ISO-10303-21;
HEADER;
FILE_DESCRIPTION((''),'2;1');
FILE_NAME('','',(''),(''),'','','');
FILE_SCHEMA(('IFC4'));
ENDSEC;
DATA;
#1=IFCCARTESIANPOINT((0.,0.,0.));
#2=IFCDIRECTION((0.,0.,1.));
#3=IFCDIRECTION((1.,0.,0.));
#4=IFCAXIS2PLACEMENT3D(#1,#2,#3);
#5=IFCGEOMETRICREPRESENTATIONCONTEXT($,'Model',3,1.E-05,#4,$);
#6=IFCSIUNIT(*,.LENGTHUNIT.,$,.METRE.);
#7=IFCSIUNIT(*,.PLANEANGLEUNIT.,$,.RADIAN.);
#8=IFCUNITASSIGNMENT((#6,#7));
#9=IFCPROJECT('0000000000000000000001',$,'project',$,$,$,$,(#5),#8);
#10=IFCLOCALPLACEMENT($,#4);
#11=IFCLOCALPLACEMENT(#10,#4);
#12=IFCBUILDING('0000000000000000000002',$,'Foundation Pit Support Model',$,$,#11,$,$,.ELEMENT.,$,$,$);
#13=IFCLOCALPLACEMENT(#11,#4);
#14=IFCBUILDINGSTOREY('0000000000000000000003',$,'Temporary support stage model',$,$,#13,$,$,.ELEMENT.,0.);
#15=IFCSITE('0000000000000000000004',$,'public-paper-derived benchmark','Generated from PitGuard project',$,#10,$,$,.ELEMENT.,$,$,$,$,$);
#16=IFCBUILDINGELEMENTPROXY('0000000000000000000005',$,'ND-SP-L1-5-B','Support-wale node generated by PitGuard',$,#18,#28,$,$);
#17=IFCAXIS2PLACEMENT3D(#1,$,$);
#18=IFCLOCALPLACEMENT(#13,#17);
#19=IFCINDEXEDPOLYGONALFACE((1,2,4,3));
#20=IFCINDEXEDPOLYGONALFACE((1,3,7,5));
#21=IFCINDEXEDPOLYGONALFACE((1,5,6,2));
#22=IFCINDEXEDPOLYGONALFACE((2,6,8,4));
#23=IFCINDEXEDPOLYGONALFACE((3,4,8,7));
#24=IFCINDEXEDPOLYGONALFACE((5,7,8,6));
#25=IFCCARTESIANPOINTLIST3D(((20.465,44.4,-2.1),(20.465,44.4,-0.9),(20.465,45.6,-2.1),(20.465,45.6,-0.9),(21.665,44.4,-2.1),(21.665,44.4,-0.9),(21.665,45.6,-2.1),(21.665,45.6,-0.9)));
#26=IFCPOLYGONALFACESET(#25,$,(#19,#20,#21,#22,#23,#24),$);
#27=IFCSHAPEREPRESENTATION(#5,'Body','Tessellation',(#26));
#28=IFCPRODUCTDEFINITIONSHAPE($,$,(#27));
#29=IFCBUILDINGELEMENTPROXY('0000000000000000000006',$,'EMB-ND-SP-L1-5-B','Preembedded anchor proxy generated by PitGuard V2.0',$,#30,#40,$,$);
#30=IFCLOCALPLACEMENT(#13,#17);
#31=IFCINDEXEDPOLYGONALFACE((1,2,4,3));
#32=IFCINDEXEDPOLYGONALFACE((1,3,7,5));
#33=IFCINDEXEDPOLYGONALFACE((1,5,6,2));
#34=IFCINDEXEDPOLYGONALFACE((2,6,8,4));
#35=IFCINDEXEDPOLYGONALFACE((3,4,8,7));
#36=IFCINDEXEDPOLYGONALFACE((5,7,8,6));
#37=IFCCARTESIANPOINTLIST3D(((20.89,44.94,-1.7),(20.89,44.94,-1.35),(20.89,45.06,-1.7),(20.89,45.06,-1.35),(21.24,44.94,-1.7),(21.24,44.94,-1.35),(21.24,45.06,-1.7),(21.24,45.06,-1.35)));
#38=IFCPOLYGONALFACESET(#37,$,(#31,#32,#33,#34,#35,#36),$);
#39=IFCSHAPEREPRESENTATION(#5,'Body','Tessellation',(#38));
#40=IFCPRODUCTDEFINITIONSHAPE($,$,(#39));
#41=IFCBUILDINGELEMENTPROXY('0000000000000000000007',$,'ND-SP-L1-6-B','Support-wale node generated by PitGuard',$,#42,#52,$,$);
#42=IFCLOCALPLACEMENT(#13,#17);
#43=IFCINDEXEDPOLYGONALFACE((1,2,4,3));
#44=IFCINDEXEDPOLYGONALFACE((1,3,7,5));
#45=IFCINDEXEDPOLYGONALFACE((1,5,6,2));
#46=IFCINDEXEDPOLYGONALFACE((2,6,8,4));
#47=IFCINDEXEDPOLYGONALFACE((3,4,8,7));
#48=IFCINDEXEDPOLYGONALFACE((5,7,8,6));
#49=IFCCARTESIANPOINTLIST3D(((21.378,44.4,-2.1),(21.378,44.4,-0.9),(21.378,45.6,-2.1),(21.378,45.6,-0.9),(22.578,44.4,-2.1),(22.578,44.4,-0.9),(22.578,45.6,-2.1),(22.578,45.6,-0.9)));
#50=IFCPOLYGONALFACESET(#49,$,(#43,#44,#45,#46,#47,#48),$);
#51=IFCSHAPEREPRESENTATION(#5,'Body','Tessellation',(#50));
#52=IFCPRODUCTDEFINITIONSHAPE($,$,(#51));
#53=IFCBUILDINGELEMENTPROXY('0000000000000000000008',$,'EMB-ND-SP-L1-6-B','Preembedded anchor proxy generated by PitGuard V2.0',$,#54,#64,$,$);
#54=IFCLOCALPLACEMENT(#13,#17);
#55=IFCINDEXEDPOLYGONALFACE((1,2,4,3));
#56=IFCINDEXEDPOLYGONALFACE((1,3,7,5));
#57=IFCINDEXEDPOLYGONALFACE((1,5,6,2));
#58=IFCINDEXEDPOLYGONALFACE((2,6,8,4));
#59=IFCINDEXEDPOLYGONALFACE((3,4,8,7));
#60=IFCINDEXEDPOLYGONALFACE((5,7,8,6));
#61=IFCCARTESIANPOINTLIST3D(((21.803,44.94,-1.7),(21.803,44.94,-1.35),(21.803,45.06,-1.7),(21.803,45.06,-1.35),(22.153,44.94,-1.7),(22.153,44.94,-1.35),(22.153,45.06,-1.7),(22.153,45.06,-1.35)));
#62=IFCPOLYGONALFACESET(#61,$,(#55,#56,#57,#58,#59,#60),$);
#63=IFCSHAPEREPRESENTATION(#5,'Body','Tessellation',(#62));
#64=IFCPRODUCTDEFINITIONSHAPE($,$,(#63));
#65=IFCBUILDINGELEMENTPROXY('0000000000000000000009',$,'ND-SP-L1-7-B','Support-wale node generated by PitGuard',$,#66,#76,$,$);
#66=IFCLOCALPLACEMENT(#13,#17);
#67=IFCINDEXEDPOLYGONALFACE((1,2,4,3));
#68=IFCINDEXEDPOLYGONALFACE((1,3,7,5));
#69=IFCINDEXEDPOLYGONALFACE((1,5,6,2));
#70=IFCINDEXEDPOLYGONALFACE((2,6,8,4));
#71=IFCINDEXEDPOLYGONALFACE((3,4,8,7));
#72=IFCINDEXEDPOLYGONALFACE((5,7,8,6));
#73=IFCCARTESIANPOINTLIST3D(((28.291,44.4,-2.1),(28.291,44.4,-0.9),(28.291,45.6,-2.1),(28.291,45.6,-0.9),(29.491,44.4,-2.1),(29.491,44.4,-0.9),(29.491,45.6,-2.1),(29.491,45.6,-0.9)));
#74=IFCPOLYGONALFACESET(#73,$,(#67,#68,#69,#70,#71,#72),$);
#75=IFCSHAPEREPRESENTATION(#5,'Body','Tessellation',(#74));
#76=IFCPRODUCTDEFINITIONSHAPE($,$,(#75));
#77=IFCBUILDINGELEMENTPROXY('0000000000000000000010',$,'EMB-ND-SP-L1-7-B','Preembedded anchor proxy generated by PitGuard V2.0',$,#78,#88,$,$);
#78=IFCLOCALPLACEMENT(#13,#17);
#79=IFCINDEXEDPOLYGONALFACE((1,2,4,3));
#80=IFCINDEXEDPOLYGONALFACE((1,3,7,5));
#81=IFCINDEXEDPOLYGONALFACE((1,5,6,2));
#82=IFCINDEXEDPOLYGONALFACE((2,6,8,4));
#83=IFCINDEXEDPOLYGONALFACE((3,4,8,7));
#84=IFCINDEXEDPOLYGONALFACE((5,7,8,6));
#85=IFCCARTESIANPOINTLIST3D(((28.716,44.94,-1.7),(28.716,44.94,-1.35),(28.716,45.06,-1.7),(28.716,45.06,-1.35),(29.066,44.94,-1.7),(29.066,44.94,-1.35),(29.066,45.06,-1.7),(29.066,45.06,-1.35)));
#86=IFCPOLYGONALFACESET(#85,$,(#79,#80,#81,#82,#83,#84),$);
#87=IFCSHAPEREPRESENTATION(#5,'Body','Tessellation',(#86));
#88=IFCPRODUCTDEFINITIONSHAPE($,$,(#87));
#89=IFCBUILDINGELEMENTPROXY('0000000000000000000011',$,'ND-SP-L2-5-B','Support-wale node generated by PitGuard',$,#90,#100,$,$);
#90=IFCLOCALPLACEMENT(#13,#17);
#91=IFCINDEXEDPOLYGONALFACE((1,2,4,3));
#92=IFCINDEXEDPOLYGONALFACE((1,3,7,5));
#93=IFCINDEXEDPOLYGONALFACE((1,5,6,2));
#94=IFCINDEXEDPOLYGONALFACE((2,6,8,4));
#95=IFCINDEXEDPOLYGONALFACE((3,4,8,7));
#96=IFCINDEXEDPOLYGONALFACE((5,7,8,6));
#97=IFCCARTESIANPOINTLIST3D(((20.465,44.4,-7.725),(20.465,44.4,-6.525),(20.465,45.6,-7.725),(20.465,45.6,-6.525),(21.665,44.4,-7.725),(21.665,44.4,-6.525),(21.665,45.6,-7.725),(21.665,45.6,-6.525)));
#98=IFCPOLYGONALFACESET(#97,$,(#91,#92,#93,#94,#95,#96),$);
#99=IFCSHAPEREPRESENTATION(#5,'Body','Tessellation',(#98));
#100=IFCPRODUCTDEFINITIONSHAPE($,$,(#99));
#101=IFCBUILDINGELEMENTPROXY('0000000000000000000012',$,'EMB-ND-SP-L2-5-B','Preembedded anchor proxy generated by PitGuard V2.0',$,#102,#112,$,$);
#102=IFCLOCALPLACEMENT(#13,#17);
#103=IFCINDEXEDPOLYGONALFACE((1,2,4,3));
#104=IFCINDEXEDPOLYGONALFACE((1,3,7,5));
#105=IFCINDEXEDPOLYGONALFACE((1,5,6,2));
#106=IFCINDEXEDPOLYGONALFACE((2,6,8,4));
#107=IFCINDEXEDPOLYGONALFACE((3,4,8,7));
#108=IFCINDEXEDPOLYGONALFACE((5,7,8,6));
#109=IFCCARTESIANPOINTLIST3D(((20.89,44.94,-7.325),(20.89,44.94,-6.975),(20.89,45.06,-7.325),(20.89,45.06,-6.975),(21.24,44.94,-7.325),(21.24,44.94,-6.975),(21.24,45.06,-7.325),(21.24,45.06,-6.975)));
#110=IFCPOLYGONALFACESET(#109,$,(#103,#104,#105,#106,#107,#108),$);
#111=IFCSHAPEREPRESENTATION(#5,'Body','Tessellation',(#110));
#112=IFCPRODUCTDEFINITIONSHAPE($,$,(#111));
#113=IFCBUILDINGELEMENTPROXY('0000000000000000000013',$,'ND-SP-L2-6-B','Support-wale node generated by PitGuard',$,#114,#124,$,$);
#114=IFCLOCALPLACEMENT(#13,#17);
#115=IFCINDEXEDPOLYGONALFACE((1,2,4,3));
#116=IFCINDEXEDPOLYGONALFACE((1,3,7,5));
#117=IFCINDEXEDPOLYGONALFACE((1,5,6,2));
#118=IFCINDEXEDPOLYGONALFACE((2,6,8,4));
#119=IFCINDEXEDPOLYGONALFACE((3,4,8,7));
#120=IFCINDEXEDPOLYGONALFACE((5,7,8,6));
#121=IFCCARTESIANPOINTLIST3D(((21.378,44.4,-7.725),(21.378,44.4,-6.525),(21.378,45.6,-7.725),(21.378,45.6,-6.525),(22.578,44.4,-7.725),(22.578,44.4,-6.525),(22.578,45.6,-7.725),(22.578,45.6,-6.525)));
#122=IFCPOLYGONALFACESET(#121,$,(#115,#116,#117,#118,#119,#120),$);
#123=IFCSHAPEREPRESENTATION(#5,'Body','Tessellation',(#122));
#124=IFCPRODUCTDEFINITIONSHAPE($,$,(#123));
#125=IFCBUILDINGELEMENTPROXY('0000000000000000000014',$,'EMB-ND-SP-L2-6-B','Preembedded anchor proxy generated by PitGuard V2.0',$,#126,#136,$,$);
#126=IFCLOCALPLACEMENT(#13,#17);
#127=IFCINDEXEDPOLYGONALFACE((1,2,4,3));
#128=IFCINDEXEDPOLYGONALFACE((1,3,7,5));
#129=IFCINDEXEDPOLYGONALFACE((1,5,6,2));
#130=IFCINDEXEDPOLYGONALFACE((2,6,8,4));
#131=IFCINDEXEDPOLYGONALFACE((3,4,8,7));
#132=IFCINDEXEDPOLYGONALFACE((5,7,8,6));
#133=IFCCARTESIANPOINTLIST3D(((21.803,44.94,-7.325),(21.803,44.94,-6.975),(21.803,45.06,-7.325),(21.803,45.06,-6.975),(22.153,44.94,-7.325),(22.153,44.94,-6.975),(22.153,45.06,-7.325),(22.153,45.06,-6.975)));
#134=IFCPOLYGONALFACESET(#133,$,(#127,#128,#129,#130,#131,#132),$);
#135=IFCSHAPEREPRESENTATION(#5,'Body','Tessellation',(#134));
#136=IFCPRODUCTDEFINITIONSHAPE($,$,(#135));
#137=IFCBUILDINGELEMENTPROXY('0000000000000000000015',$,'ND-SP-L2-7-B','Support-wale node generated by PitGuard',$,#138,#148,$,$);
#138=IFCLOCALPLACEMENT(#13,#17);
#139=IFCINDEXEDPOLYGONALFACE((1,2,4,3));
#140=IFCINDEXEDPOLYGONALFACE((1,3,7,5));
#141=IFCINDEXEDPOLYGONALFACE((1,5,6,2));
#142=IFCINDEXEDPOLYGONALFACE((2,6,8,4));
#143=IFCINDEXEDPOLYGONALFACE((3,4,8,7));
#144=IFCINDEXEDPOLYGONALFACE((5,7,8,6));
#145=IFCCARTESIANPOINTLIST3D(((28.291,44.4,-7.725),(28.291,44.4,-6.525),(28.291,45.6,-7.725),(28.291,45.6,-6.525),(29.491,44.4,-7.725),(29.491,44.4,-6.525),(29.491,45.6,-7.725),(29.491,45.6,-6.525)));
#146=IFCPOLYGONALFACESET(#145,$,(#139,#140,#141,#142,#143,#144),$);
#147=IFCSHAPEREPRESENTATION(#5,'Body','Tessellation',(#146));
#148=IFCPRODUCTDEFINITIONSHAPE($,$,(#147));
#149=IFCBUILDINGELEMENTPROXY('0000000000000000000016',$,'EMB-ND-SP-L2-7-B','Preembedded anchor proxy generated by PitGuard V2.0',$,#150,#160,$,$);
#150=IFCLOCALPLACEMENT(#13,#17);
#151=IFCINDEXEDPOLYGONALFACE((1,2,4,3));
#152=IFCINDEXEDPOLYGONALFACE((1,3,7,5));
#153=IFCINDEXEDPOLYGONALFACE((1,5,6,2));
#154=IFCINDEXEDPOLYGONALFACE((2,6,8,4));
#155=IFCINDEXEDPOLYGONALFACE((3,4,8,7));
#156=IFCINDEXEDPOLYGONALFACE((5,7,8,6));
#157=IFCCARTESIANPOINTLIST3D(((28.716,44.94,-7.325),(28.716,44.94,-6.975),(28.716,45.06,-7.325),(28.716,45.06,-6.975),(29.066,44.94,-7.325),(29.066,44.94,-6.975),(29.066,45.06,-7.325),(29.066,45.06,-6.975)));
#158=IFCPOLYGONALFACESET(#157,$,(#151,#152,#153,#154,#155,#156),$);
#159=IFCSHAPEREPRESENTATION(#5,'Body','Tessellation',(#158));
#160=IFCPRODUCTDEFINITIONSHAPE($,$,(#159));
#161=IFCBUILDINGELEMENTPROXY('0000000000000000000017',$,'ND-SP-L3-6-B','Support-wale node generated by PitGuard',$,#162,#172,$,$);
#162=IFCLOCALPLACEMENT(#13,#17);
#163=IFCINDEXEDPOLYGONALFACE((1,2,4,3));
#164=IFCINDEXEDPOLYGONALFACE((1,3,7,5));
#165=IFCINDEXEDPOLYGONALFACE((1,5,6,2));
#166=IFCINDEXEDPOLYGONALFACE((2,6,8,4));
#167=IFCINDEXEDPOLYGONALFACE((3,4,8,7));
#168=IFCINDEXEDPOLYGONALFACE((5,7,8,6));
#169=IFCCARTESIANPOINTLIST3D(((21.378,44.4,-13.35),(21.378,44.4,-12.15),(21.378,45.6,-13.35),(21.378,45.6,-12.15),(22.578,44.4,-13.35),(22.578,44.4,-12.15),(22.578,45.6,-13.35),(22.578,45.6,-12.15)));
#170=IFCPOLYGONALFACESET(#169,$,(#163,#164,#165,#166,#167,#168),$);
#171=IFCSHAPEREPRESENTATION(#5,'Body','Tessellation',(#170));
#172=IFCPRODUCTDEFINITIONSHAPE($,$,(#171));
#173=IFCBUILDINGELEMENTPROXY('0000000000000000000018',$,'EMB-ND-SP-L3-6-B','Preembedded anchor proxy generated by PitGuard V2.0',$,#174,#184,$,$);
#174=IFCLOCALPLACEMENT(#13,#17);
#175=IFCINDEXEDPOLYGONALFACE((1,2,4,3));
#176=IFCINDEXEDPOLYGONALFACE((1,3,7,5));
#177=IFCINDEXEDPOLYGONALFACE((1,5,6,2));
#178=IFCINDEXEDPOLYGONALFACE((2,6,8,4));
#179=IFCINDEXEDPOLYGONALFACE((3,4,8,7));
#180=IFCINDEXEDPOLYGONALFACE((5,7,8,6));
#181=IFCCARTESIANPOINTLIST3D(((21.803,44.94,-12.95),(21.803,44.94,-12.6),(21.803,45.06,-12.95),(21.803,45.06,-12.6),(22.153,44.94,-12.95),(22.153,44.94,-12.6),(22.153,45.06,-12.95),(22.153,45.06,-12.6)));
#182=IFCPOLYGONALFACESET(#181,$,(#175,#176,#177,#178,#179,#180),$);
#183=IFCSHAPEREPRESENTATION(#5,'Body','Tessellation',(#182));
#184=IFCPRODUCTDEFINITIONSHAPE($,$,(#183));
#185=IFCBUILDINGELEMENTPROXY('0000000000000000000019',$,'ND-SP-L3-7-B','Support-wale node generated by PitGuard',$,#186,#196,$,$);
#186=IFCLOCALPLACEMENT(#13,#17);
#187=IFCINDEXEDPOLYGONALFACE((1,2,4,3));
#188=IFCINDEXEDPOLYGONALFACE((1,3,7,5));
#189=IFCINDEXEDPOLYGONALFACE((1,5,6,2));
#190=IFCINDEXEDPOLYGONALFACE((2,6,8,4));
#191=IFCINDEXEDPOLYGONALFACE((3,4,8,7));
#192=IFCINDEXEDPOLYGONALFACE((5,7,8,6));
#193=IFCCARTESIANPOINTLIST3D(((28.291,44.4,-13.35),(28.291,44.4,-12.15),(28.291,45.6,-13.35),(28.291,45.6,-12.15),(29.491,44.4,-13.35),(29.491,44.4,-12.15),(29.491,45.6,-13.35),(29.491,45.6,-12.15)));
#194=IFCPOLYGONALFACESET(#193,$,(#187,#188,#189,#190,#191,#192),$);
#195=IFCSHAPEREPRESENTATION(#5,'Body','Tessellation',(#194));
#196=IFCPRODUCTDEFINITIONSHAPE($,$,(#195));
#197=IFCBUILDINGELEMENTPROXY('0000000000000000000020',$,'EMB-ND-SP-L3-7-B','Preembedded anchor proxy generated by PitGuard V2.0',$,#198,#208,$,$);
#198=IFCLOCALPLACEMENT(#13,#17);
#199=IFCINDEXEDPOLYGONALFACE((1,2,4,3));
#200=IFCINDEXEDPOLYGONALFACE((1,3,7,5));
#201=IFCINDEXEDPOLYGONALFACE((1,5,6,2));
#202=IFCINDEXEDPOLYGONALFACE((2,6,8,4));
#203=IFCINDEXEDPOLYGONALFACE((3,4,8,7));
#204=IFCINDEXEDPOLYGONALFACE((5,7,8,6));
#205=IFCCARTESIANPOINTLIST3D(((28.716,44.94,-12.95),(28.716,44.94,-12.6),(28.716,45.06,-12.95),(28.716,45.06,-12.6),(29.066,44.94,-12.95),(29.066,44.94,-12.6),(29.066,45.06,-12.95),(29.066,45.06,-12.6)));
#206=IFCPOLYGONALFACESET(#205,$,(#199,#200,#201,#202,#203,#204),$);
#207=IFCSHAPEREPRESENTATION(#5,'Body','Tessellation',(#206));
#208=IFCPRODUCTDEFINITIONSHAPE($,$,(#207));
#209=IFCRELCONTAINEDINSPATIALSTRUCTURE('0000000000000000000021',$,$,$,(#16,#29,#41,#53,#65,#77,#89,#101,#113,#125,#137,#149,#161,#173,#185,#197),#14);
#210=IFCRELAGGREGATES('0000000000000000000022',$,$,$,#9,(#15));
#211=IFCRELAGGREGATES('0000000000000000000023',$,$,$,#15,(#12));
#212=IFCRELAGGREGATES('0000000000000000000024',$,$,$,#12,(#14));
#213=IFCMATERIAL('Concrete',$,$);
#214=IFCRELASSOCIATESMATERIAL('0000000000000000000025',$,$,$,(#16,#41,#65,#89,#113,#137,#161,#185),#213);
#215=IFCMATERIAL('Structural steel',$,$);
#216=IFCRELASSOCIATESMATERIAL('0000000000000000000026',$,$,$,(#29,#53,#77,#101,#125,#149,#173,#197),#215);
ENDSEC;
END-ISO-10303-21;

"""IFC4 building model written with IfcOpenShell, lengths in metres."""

from ifc_helpers import new_model, si_unit, frame, origin_with_axes, origin_2d, place, context, project, spatial, rectangle, extrude, material, element, save


model = new_model("IFC4")

# Units and contexts
model_context = context("Model", 3, precision=1e-05, world=origin_with_axes())
ifc_project = project(units=[si_unit("LENGTHUNIT", "METRE"), si_unit("PLANEANGLEUNIT", "RADIAN")], contexts=[model_context])

# Site, building, storey
site_placement = place(None, origin_with_axes())
site = spatial("IfcSite", under=ifc_project, at=site_placement, Name="public-paper-derived benchmark", Description="Generated from PitGuard project", CompositionType="ELEMENT")
building_placement = place(site_placement, origin_with_axes())
building = spatial("IfcBuilding", under=site, at=building_placement, Name="Foundation Pit Support Model", CompositionType="ELEMENT")
storey_placement = place(building_placement, origin_with_axes())
storey = spatial("IfcBuildingStorey", under=building, at=storey_placement, Name="Temporary support stage model", CompositionType="ELEMENT", Elevation=0.0)

# Shared definitions
ifc_material_1 = material(Name="Concrete")

# Shared definitions
ifc_material_2 = material(Name="Structural steel")

# Building element proxies
proxy_1_placement = place(storey_placement, frame((21.065, 45.0, -2.1), z_axis=(0.0, 0.0, 1.0), x_axis=(1.0, 0.0, 0.0)))
element("IfcBuildingElementProxy", 1, at=proxy_1_placement, inside=storey, material=ifc_material_1, Name="ND-SP-L1-5-B", Description="Support-wale node generated by PitGuard", context=model_context, shape_type="SweptSolid", body=[
    extrude(rectangle(XDim=1.2, YDim=1.2, at=origin_2d()), origin_with_axes(), (0.0, 0.0, 1.0), 1.2),
])
proxy_2_placement = place(storey_placement, frame((21.065, 45.0, -1.7), z_axis=(0.0, 0.0, 1.0), x_axis=(1.0, 0.0, 0.0)))
element("IfcBuildingElementProxy", 2, at=proxy_2_placement, inside=storey, material=ifc_material_2, Name="EMB-ND-SP-L1-5-B", Description="Preembedded anchor proxy generated by PitGuard V2.0", context=model_context, shape_type="SweptSolid", body=[
    extrude(rectangle(XDim=0.35, YDim=0.12, at=origin_2d()), origin_with_axes(), (0.0, 0.0, 1.0), 0.35),
])
proxy_3_placement = place(storey_placement, frame((21.978, 45.0, -2.1), z_axis=(0.0, 0.0, 1.0), x_axis=(1.0, 0.0, 0.0)))
element("IfcBuildingElementProxy", 3, at=proxy_3_placement, inside=storey, material=ifc_material_1, Name="ND-SP-L1-6-B", Description="Support-wale node generated by PitGuard", context=model_context, shape_type="SweptSolid", body=[
    extrude(rectangle(XDim=1.2, YDim=1.2, at=origin_2d()), origin_with_axes(), (0.0, 0.0, 1.0), 1.2),
])
proxy_4_placement = place(storey_placement, frame((21.978, 45.0, -1.7), z_axis=(0.0, 0.0, 1.0), x_axis=(1.0, 0.0, 0.0)))
element("IfcBuildingElementProxy", 4, at=proxy_4_placement, inside=storey, material=ifc_material_2, Name="EMB-ND-SP-L1-6-B", Description="Preembedded anchor proxy generated by PitGuard V2.0", context=model_context, shape_type="SweptSolid", body=[
    extrude(rectangle(XDim=0.35, YDim=0.12, at=origin_2d()), origin_with_axes(), (0.0, 0.0, 1.0), 0.35),
])
proxy_5_placement = place(storey_placement, frame((28.891, 45.0, -2.1), z_axis=(0.0, 0.0, 1.0), x_axis=(1.0, 0.0, 0.0)))
element("IfcBuildingElementProxy", 5, at=proxy_5_placement, inside=storey, material=ifc_material_1, Name="ND-SP-L1-7-B", Description="Support-wale node generated by PitGuard", context=model_context, shape_type="SweptSolid", body=[
    extrude(rectangle(XDim=1.2, YDim=1.2, at=origin_2d()), origin_with_axes(), (0.0, 0.0, 1.0), 1.2),
])
proxy_6_placement = place(storey_placement, frame((28.891, 45.0, -1.7), z_axis=(0.0, 0.0, 1.0), x_axis=(1.0, 0.0, 0.0)))
element("IfcBuildingElementProxy", 6, at=proxy_6_placement, inside=storey, material=ifc_material_2, Name="EMB-ND-SP-L1-7-B", Description="Preembedded anchor proxy generated by PitGuard V2.0", context=model_context, shape_type="SweptSolid", body=[
    extrude(rectangle(XDim=0.35, YDim=0.12, at=origin_2d()), origin_with_axes(), (0.0, 0.0, 1.0), 0.35),
])
proxy_7_placement = place(storey_placement, frame((21.065, 45.0, -7.725), z_axis=(0.0, 0.0, 1.0), x_axis=(1.0, 0.0, 0.0)))
element("IfcBuildingElementProxy", 7, at=proxy_7_placement, inside=storey, material=ifc_material_1, Name="ND-SP-L2-5-B", Description="Support-wale node generated by PitGuard", context=model_context, shape_type="SweptSolid", body=[
    extrude(rectangle(XDim=1.2, YDim=1.2, at=origin_2d()), origin_with_axes(), (0.0, 0.0, 1.0), 1.2),
])
proxy_8_placement = place(storey_placement, frame((21.065, 45.0, -7.325), z_axis=(0.0, 0.0, 1.0), x_axis=(1.0, 0.0, 0.0)))
element("IfcBuildingElementProxy", 8, at=proxy_8_placement, inside=storey, material=ifc_material_2, Name="EMB-ND-SP-L2-5-B", Description="Preembedded anchor proxy generated by PitGuard V2.0", context=model_context, shape_type="SweptSolid", body=[
    extrude(rectangle(XDim=0.35, YDim=0.12, at=origin_2d()), origin_with_axes(), (0.0, 0.0, 1.0), 0.35),
])
proxy_9_placement = place(storey_placement, frame((21.978, 45.0, -7.725), z_axis=(0.0, 0.0, 1.0), x_axis=(1.0, 0.0, 0.0)))
element("IfcBuildingElementProxy", 9, at=proxy_9_placement, inside=storey, material=ifc_material_1, Name="ND-SP-L2-6-B", Description="Support-wale node generated by PitGuard", context=model_context, shape_type="SweptSolid", body=[
    extrude(rectangle(XDim=1.2, YDim=1.2, at=origin_2d()), origin_with_axes(), (0.0, 0.0, 1.0), 1.2),
])
proxy_10_placement = place(storey_placement, frame((21.978, 45.0, -7.325), z_axis=(0.0, 0.0, 1.0), x_axis=(1.0, 0.0, 0.0)))
element("IfcBuildingElementProxy", 10, at=proxy_10_placement, inside=storey, material=ifc_material_2, Name="EMB-ND-SP-L2-6-B", Description="Preembedded anchor proxy generated by PitGuard V2.0", context=model_context, shape_type="SweptSolid", body=[
    extrude(rectangle(XDim=0.35, YDim=0.12, at=origin_2d()), origin_with_axes(), (0.0, 0.0, 1.0), 0.35),
])
proxy_11_placement = place(storey_placement, frame((28.891, 45.0, -7.725), z_axis=(0.0, 0.0, 1.0), x_axis=(1.0, 0.0, 0.0)))
element("IfcBuildingElementProxy", 11, at=proxy_11_placement, inside=storey, material=ifc_material_1, Name="ND-SP-L2-7-B", Description="Support-wale node generated by PitGuard", context=model_context, shape_type="SweptSolid", body=[
    extrude(rectangle(XDim=1.2, YDim=1.2, at=origin_2d()), origin_with_axes(), (0.0, 0.0, 1.0), 1.2),
])
proxy_12_placement = place(storey_placement, frame((28.891, 45.0, -7.325), z_axis=(0.0, 0.0, 1.0), x_axis=(1.0, 0.0, 0.0)))
element("IfcBuildingElementProxy", 12, at=proxy_12_placement, inside=storey, material=ifc_material_2, Name="EMB-ND-SP-L2-7-B", Description="Preembedded anchor proxy generated by PitGuard V2.0", context=model_context, shape_type="SweptSolid", body=[
    extrude(rectangle(XDim=0.35, YDim=0.12, at=origin_2d()), origin_with_axes(), (0.0, 0.0, 1.0), 0.35),
])
proxy_13_placement = place(storey_placement, frame((21.978, 45.0, -13.35), z_axis=(0.0, 0.0, 1.0), x_axis=(1.0, 0.0, 0.0)))
element("IfcBuildingElementProxy", 13, at=proxy_13_placement, inside=storey, material=ifc_material_1, Name="ND-SP-L3-6-B", Description="Support-wale node generated by PitGuard", context=model_context, shape_type="SweptSolid", body=[
    extrude(rectangle(XDim=1.2, YDim=1.2, at=origin_2d()), origin_with_axes(), (0.0, 0.0, 1.0), 1.2),
])
proxy_14_placement = place(storey_placement, frame((21.978, 45.0, -12.95), z_axis=(0.0, 0.0, 1.0), x_axis=(1.0, 0.0, 0.0)))
element("IfcBuildingElementProxy", 14, at=proxy_14_placement, inside=storey, material=ifc_material_2, Name="EMB-ND-SP-L3-6-B", Description="Preembedded anchor proxy generated by PitGuard V2.0", context=model_context, shape_type="SweptSolid", body=[
    extrude(rectangle(XDim=0.35, YDim=0.12, at=origin_2d()), origin_with_axes(), (0.0, 0.0, 1.0), 0.35),
])
proxy_15_placement = place(storey_placement, frame((28.891, 45.0, -13.35), z_axis=(0.0, 0.0, 1.0), x_axis=(1.0, 0.0, 0.0)))
element("IfcBuildingElementProxy", 15, at=proxy_15_placement, inside=storey, material=ifc_material_1, Name="ND-SP-L3-7-B", Description="Support-wale node generated by PitGuard", context=model_context, shape_type="SweptSolid", body=[
    extrude(rectangle(XDim=1.2, YDim=1.2, at=origin_2d()), origin_with_axes(), (0.0, 0.0, 1.0), 1.2),
])
proxy_16_placement = place(storey_placement, frame((28.891, 45.0, -12.95), z_axis=(0.0, 0.0, 1.0), x_axis=(1.0, 0.0, 0.0)))
element("IfcBuildingElementProxy", 16, at=proxy_16_placement, inside=storey, material=ifc_material_2, Name="EMB-ND-SP-L3-7-B", Description="Preembedded anchor proxy generated by PitGuard V2.0", context=model_context, shape_type="SweptSolid", body=[
    extrude(rectangle(XDim=0.35, YDim=0.12, at=origin_2d()), origin_with_axes(), (0.0, 0.0, 1.0), 0.35),
])

save(model, "model.ifc")
